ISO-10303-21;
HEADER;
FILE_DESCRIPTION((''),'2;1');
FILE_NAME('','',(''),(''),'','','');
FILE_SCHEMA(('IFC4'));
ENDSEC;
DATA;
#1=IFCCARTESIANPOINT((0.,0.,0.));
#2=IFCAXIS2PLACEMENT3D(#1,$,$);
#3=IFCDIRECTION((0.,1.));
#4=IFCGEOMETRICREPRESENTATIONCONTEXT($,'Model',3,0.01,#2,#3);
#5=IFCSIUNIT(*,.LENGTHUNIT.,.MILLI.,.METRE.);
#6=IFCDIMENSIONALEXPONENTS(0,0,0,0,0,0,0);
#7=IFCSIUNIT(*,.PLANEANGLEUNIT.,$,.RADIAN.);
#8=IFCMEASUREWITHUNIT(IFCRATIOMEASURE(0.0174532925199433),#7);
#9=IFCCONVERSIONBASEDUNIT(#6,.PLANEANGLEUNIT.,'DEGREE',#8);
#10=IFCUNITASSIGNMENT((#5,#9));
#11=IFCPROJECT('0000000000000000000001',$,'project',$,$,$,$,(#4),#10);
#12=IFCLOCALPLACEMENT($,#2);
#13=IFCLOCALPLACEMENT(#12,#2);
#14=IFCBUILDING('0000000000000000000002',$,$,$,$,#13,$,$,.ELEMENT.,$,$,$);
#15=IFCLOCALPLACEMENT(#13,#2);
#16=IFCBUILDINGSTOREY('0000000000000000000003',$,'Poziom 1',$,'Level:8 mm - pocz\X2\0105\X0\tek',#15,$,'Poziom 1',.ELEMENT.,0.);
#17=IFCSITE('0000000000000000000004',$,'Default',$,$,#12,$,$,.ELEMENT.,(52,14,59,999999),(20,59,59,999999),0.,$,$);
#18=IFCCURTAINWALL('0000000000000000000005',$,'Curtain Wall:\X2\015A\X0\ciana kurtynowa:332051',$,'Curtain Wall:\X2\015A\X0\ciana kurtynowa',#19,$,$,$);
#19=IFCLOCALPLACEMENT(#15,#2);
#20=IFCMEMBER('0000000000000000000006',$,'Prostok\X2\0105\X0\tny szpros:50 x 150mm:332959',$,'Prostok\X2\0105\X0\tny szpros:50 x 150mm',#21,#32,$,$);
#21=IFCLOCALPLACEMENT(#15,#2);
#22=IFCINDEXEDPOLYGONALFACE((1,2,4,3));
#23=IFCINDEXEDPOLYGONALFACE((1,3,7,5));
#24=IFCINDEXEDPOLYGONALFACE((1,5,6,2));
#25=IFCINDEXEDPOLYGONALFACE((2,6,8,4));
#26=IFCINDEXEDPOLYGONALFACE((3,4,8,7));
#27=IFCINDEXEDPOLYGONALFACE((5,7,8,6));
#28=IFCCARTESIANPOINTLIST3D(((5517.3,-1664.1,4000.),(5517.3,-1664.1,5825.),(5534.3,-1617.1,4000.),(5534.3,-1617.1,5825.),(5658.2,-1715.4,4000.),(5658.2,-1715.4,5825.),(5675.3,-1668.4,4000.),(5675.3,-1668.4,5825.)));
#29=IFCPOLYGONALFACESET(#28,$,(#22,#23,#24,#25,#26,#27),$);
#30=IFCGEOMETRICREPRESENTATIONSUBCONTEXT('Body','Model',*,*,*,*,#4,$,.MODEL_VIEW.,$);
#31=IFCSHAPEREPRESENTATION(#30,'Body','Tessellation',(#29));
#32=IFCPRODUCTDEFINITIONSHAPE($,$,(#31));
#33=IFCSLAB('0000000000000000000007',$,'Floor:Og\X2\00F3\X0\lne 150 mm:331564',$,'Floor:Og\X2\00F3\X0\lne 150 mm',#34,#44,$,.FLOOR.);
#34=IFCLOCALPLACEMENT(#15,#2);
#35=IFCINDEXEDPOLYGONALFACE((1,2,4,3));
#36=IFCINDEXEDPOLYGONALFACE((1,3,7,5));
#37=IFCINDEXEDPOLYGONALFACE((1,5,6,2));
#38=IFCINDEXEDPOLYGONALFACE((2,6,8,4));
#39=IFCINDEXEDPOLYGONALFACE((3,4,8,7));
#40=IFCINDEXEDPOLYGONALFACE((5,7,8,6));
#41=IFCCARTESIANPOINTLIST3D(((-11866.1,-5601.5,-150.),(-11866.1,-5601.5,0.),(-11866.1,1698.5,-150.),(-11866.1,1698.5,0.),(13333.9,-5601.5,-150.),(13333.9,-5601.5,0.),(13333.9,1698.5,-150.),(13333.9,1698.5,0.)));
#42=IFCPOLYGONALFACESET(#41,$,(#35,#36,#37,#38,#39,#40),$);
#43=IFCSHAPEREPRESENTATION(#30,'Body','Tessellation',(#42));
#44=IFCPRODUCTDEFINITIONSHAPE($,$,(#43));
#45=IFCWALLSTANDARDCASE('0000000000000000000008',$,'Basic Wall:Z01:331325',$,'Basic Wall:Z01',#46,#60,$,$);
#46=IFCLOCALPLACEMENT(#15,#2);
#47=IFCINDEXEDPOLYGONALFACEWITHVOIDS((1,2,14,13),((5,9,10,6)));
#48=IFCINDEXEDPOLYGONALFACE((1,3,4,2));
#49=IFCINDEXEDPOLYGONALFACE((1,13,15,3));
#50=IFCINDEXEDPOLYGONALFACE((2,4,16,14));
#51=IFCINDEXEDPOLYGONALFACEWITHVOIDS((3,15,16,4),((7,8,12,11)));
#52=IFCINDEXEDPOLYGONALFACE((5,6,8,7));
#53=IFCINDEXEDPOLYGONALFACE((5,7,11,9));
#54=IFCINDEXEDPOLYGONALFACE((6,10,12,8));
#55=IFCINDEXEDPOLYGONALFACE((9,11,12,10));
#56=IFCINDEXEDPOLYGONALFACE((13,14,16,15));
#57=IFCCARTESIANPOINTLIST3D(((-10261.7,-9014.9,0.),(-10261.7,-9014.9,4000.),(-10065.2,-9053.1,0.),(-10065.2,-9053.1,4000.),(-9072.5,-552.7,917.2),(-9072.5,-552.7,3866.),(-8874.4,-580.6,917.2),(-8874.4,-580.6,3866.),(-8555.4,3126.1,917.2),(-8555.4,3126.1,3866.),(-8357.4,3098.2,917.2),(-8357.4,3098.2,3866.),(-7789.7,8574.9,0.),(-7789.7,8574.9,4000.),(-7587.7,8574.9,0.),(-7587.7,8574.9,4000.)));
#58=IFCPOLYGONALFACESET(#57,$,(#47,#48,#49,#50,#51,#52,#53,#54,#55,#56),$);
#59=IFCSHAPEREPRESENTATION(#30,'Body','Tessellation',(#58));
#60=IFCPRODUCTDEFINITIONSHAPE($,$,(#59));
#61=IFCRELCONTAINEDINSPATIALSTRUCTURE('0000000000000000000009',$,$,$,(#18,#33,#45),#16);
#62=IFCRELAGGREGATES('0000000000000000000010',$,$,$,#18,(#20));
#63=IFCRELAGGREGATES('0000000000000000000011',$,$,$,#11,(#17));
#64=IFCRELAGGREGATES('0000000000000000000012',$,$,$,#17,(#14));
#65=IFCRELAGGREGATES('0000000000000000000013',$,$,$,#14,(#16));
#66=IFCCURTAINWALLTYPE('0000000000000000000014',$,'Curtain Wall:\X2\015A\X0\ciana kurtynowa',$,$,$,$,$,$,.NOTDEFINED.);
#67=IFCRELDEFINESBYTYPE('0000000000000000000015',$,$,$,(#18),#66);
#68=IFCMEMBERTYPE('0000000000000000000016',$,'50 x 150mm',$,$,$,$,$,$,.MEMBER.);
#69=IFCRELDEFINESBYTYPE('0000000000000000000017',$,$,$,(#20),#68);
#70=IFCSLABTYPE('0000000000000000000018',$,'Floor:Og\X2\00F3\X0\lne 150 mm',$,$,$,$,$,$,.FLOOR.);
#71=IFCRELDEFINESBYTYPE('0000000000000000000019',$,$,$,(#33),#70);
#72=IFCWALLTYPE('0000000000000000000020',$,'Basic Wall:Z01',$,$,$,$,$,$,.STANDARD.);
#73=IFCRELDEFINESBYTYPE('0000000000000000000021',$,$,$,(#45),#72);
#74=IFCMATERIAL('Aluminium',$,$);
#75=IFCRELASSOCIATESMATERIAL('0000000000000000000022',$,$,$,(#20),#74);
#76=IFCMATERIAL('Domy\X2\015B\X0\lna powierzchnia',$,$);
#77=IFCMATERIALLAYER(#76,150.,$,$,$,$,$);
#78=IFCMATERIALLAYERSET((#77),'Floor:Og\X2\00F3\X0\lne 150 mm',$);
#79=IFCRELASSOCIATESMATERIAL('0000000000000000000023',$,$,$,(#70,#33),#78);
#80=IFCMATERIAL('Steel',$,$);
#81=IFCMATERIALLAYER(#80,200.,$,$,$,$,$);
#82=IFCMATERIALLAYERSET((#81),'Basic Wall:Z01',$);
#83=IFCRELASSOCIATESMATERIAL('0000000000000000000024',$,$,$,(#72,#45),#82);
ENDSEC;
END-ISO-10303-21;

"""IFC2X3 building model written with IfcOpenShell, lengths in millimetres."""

from ifc_helpers import new_model, entity, si_unit, converted_unit, direction, frame, frame_2d, origin, origin_2d_with_axis, place, context, subcontext, project, spatial, polyline, rectangle, outline, extrude, clip, halfspace, source, transform, mapped, material, layer, layer_set, layer_usage, type_object, type_shapes, element, aggregate, save


model = new_model("IFC2X3")

# Units and contexts
model_context = context("Model", 3, precision=0.01, world=origin(), true_north=direction((0.0, 1.0)))
body_context = subcontext(model_context, "Body", "Model", "MODEL_VIEW")
ifc_project = project(units=[si_unit("LENGTHUNIT", "METRE", prefix="MILLI"), converted_unit("PLANEANGLEUNIT", "DEGREE", entity("IfcRatioMeasure", 0.0174532925199433), si_unit("PLANEANGLEUNIT", "RADIAN"), dimensions=[0, 0, 0, 0, 0, 0, 0])], contexts=[model_context])

# Site, building, storey
site_placement = place(None, origin())
site = spatial("IfcSite", under=ifc_project, at=site_placement, Name="Default", CompositionType="ELEMENT", RefLatitude=(52, 14, 59, 999999), RefLongitude=(20, 59, 59, 999999), RefElevation=0.0)
building_placement = place(site_placement, origin())
building = spatial("IfcBuilding", under=site, at=building_placement, CompositionType="ELEMENT")
storey_placement = place(building_placement, origin())
storey = spatial("IfcBuildingStorey", under=building, at=storey_placement, Name="Poziom 1", ObjectType="Level:8 mm - początek", LongName="Poziom 1", CompositionType="ELEMENT", Elevation=0.0)

# Curtain wall, member
curtain_wall_type = type_object("IfcCurtainWallType", Name="Curtain Wall:Ściana kurtynowa", PredefinedType="NOTDEFINED")
curtain_wall_placement = place(storey_placement, origin())
curtain_wall = element("IfcCurtainWall", 1, at=curtain_wall_placement, inside=storey, type_object=curtain_wall_type, Name="Curtain Wall:Ściana kurtynowa:332051", ObjectType="Curtain Wall:Ściana kurtynowa")
ifc_material_1 = material(Name="Aluminium")
member_type_1 = type_object("IfcMemberType", Name="50 x 150mm", PredefinedType="MEMBER")
shared_shape_1 = source(origin(), body_context, "Body", "SweptSolid", [
    extrude(rectangle(XDim=150.0, YDim=50.0, at=origin_2d_with_axis()), frame((0.0, 0.0, -1825.0), z_axis=(0.0, 0.0, 1.0), x_axis=(0.0, -1.0, 0.0)), (0.0, 0.0, 1.0), 1825.0),
])
type_shapes(member_type_1, [shared_shape_1])
member_1_placement = place(storey_placement, frame((5596.3, -1666.3, 4000.0), z_axis=(0.0, 0.0, -1.0), x_axis=(0.341586, 0.939851, 0.0)))
member_1 = element("IfcMember", 2, at=member_1_placement, type_object=member_type_1, material=ifc_material_1, Name="Prostokątny szpros:50 x 150mm:332959", ObjectType="Prostokątny szpros:50 x 150mm", context=body_context, shape_type="MappedRepresentation", body=[
    mapped(shared_shape_1, transform((0.0, 0.0, 0.0), scale=1.0)),
])

# Slab
ifc_material_2 = material(Name="Domyślna powierzchnia")
ifc_layer_1 = layer(ifc_material_2, 150.0)
ifc_layer_set_1 = layer_set([ifc_layer_1], Name="Floor:Ogólne 150 mm")
ifc_layer_usage_1 = layer_usage(ifc_layer_set_1, "AXIS3", "POSITIVE", 0.0)
slab_type = type_object("IfcSlabType", Name="Floor:Ogólne 150 mm", PredefinedType="FLOOR", material=ifc_layer_set_1)
slab_placement = place(storey_placement, origin())
element("IfcSlab", 3, at=slab_placement, inside=storey, type_object=slab_type, material=ifc_layer_usage_1, Name="Floor:Ogólne 150 mm:331564", ObjectType="Floor:Ogólne 150 mm", PredefinedType="FLOOR", context=body_context, shape_type="SweptSolid", body=[
    extrude(rectangle(XDim=7300.0, YDim=25200.0, at=frame_2d((0.0, 0.0), x_axis=(1.0, 0.0))), frame((733.9, -1951.5, 0.0), z_axis=(0.0, 0.0, -1.0), x_axis=(0.0, 1.0, 0.0)), (0.0, 0.0, 1.0), 150.0),
])

aggregate(curtain_wall, [member_1])

# Wall, opening
ifc_material_3 = material(Name="Steel")
ifc_layer_2 = layer(ifc_material_3, 200.0)
ifc_layer_set_2 = layer_set([ifc_layer_2], Name="Basic Wall:Z01")
ifc_layer_usage_2 = layer_usage(ifc_layer_set_2, "AXIS2", "NEGATIVE", 100.0)
wall_type = type_object("IfcWallType", Name="Basic Wall:Z01", PredefinedType="STANDARD", material=ifc_layer_set_2)
wall_1_placement = place(storey_placement, frame((-7686.7, 8588.8, 0.0), z_axis=(0.0, 0.0, 1.0), x_axis=(-0.139173, -0.990268, 0.0)))
wall_1 = element("IfcWallStandardCase", 4, at=wall_1_placement, inside=storey, type_object=wall_type, material=ifc_layer_usage_2, Name="Basic Wall:Z01:331325", ObjectType="Basic Wall:Z01", context=body_context, shape_type="Clipping", body=[
    clip(extrude(outline(polyline([(17790.8, -100.0), (17801.2, 100.0), (17300.6, 100.0), (504.9, 100.0), (0.0, 100.0), (28.1, -100.0), (17790.8, -100.0)])), origin(), (0.0, 0.0, 1.0), 4000.0), halfspace(origin(), True)),
])
opening_1_placement = place(wall_1_placement, origin())
element("IfcOpeningElement", 5, at=opening_1_placement, cuts=wall_1, ObjectType="Opening", context=body_context, shape_type="SweptSolid", body=[
    extrude(rectangle(XDim=2948.8, YDim=3715.0, at=origin_2d_with_axis()), frame((7387.9, -100.0, 2391.6), z_axis=(0.0, 1.0, 0.0), x_axis=(0.0, 0.0, -1.0)), (0.0, 0.0, 1.0), 200.0),
])

save(model, "model.ifc")
